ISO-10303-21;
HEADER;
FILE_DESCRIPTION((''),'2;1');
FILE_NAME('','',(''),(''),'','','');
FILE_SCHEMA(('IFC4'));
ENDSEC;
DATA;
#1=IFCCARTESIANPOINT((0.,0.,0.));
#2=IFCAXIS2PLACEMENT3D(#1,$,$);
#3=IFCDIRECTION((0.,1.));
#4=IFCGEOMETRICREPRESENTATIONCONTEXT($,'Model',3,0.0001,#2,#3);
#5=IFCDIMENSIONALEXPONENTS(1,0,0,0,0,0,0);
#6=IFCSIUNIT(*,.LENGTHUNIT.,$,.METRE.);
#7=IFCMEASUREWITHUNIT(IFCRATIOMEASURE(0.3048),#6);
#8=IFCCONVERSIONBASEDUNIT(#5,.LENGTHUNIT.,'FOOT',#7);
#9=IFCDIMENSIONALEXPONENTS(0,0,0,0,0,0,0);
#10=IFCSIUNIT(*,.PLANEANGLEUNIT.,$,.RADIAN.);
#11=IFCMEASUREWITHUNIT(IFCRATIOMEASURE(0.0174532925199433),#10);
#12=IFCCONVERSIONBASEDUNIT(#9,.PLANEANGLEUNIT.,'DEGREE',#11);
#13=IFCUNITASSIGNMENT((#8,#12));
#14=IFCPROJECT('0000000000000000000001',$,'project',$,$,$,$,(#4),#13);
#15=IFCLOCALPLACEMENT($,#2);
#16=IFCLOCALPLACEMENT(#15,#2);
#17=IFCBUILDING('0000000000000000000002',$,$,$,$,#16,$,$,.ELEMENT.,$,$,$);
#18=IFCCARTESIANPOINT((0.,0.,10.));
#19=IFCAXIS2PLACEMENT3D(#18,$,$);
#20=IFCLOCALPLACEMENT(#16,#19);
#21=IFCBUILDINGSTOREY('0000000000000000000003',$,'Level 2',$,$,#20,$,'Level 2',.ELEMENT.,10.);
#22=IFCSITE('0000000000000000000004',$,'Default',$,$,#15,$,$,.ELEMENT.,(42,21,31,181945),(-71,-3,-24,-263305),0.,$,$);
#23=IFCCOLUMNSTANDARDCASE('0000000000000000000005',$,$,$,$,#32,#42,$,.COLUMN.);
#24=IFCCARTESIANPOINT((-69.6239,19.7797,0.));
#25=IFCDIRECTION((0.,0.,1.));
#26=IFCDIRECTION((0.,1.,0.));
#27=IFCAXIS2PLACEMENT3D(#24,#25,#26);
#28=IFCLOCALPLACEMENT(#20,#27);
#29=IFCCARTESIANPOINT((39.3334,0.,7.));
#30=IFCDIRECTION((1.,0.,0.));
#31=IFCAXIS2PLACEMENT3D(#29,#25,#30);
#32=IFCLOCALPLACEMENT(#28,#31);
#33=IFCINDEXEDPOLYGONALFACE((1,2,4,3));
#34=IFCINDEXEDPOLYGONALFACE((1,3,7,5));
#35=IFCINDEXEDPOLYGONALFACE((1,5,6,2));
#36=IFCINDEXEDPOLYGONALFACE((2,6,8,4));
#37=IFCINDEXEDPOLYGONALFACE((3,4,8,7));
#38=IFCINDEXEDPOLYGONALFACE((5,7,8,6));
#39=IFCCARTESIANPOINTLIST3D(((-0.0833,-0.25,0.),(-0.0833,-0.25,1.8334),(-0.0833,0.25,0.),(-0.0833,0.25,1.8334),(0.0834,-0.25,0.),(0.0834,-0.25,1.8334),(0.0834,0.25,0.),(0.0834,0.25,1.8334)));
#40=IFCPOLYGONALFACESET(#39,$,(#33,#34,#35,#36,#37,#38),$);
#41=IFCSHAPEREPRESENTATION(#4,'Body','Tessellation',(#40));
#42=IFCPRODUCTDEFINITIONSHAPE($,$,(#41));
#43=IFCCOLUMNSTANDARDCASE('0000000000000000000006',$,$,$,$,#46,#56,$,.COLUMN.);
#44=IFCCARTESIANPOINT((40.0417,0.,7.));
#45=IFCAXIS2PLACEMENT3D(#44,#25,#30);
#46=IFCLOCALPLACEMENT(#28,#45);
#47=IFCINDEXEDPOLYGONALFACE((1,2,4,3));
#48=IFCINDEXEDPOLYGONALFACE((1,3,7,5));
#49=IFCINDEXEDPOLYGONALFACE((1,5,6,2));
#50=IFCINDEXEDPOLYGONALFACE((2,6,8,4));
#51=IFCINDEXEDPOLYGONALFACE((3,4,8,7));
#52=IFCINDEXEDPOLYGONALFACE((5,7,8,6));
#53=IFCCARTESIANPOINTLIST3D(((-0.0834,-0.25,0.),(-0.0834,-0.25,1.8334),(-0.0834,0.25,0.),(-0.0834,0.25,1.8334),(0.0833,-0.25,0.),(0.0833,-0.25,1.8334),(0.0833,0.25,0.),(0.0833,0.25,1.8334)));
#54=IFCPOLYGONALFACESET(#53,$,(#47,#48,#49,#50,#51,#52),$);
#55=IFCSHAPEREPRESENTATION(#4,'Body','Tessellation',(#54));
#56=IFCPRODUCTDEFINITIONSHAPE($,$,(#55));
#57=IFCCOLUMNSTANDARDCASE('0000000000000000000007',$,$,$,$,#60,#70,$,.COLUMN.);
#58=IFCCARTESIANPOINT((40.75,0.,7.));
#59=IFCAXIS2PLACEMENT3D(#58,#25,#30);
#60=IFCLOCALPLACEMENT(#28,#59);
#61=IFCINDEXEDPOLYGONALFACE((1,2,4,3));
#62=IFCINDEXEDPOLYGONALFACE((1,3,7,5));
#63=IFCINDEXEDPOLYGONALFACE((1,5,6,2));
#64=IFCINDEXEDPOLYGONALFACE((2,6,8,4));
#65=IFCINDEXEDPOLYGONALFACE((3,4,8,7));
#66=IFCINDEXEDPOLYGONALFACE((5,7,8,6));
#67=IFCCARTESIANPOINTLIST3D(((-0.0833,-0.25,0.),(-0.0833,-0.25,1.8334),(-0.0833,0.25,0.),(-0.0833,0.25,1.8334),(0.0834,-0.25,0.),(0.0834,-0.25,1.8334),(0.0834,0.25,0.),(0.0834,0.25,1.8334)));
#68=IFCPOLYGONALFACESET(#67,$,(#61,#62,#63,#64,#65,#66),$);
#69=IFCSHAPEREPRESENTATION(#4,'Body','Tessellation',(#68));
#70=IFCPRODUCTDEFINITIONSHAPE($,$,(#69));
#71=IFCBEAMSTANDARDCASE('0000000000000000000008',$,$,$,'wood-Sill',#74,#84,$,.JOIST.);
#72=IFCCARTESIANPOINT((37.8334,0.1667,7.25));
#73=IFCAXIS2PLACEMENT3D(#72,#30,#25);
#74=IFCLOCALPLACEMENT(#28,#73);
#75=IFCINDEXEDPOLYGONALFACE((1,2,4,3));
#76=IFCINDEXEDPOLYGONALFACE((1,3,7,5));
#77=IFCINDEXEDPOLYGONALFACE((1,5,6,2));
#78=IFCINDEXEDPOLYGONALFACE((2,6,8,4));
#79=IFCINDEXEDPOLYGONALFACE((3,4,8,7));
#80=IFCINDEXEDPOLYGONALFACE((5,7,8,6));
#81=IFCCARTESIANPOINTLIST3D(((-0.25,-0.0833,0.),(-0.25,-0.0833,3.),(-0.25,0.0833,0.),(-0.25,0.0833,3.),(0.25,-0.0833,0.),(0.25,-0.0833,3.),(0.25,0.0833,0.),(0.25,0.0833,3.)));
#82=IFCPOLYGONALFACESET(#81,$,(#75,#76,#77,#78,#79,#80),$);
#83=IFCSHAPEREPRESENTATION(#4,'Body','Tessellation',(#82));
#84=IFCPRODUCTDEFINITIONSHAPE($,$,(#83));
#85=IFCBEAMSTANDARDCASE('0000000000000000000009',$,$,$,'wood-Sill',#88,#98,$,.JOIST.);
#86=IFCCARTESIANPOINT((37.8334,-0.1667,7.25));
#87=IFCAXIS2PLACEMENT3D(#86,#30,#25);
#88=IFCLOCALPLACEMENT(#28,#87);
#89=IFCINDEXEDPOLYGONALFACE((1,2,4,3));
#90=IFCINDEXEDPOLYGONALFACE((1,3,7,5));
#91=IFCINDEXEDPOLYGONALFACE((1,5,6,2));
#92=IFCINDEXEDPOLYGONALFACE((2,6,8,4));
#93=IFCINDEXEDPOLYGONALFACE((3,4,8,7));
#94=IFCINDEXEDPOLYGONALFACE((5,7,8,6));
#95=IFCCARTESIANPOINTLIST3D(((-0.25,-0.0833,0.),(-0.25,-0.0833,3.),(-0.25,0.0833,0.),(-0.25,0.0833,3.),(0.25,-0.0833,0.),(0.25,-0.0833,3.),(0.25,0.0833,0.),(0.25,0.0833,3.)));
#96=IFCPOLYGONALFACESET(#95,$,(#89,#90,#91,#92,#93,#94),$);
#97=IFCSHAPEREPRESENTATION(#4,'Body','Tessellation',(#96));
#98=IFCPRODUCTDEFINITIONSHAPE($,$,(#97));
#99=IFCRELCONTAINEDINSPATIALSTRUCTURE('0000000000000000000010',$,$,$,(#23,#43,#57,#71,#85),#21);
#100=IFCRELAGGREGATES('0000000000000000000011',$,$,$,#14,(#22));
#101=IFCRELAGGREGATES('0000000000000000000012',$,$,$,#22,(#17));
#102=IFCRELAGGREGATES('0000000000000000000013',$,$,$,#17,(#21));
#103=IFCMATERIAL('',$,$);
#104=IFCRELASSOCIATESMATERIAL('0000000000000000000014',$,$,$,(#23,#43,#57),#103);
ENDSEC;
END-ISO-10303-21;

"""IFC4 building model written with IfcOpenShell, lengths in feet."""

from ifc_helpers import new_model, entity, si_unit, converted_unit, direction, frame, origin, origin_with_axes, place, context, project, spatial, rectangle, extrude, material, element, save


model = new_model("IFC4")

# Units and contexts
model_context = context("Model", 3, precision=0.0001, world=origin(), true_north=direction((0.0, 1.0)))
ifc_project = project(units=[converted_unit("LENGTHUNIT", "FOOT", entity("IfcRatioMeasure", 0.3048), si_unit("LENGTHUNIT", "METRE"), dimensions=[1, 0, 0, 0, 0, 0, 0]), converted_unit("PLANEANGLEUNIT", "DEGREE", entity("IfcRatioMeasure", 0.0174532925199433), si_unit("PLANEANGLEUNIT", "RADIAN"), dimensions=[0, 0, 0, 0, 0, 0, 0])], contexts=[model_context])

# Site, building, storey
site_placement = place(None, origin())
site = spatial("IfcSite", under=ifc_project, at=site_placement, Name="Default", CompositionType="ELEMENT", RefLatitude=(42, 21, 31, 181945), RefLongitude=(-71, -3, -24, -263305), RefElevation=0.0)
building_placement = place(site_placement, origin())
building = spatial("IfcBuilding", under=site, at=building_placement, CompositionType="ELEMENT")
storey_placement = place(building_placement, frame((0.0, 0.0, 10.0)))
storey = spatial("IfcBuildingStorey", under=building, at=storey_placement, Name="Level 2", LongName="Level 2", CompositionType="ELEMENT", Elevation=10.0)

# Columns
placement = place(storey_placement, frame((-69.6239, 19.7797, 0.0), z_axis=(0.0, 0.0, 1.0), x_axis=(0.0, 1.0, 0.0)))
ifc_material_1 = material(Name="")
for number, where, z_axis, x_axis in (
    (1, (39.3334, 0.0, 7.0), (0.0, 0.0, 1.0), (1.0, 0.0, 0.0)),
    (2, (40.0417, 0.0, 7.0), (0.0, 0.0, 1.0), (1.0, 0.0, 0.0)),
    (3, (40.75, 0.0, 7.0), (0.0, 0.0, 1.0), (1.0, 0.0, 0.0)),
):
    element("IfcColumnStandardCase", number, at=place(placement, frame(where, z_axis=z_axis, x_axis=x_axis)), inside=storey, material=ifc_material_1, PredefinedType="COLUMN", context=model_context, shape_type="SweptSolid", body=[
        extrude(rectangle(XDim=0.1667, YDim=0.5), origin(), (0.0, 0.0, 1.0), 1.8334),
    ])

# Beams
for number, where, z_axis, x_axis in (
    (4, (37.8334, 0.1667, 7.25), (1.0, 0.0, 0.0), (0.0, 0.0, 1.0)),
    (5, (37.8334, -0.1667, 7.25), (1.0, 0.0, 0.0), (0.0, 0.0, 1.0)),
):
    element("IfcBeamStandardCase", number, at=place(placement, frame(where, z_axis=z_axis, x_axis=x_axis)), inside=storey, ObjectType="wood-Sill", PredefinedType="JOIST", context=model_context, shape_type="SweptSolid", body=[
        extrude(rectangle(XDim=0.5, YDim=0.1667), origin_with_axes(), (0.0, 0.0, 1.0), 3.0),
    ])

save(model, "model.ifc")
